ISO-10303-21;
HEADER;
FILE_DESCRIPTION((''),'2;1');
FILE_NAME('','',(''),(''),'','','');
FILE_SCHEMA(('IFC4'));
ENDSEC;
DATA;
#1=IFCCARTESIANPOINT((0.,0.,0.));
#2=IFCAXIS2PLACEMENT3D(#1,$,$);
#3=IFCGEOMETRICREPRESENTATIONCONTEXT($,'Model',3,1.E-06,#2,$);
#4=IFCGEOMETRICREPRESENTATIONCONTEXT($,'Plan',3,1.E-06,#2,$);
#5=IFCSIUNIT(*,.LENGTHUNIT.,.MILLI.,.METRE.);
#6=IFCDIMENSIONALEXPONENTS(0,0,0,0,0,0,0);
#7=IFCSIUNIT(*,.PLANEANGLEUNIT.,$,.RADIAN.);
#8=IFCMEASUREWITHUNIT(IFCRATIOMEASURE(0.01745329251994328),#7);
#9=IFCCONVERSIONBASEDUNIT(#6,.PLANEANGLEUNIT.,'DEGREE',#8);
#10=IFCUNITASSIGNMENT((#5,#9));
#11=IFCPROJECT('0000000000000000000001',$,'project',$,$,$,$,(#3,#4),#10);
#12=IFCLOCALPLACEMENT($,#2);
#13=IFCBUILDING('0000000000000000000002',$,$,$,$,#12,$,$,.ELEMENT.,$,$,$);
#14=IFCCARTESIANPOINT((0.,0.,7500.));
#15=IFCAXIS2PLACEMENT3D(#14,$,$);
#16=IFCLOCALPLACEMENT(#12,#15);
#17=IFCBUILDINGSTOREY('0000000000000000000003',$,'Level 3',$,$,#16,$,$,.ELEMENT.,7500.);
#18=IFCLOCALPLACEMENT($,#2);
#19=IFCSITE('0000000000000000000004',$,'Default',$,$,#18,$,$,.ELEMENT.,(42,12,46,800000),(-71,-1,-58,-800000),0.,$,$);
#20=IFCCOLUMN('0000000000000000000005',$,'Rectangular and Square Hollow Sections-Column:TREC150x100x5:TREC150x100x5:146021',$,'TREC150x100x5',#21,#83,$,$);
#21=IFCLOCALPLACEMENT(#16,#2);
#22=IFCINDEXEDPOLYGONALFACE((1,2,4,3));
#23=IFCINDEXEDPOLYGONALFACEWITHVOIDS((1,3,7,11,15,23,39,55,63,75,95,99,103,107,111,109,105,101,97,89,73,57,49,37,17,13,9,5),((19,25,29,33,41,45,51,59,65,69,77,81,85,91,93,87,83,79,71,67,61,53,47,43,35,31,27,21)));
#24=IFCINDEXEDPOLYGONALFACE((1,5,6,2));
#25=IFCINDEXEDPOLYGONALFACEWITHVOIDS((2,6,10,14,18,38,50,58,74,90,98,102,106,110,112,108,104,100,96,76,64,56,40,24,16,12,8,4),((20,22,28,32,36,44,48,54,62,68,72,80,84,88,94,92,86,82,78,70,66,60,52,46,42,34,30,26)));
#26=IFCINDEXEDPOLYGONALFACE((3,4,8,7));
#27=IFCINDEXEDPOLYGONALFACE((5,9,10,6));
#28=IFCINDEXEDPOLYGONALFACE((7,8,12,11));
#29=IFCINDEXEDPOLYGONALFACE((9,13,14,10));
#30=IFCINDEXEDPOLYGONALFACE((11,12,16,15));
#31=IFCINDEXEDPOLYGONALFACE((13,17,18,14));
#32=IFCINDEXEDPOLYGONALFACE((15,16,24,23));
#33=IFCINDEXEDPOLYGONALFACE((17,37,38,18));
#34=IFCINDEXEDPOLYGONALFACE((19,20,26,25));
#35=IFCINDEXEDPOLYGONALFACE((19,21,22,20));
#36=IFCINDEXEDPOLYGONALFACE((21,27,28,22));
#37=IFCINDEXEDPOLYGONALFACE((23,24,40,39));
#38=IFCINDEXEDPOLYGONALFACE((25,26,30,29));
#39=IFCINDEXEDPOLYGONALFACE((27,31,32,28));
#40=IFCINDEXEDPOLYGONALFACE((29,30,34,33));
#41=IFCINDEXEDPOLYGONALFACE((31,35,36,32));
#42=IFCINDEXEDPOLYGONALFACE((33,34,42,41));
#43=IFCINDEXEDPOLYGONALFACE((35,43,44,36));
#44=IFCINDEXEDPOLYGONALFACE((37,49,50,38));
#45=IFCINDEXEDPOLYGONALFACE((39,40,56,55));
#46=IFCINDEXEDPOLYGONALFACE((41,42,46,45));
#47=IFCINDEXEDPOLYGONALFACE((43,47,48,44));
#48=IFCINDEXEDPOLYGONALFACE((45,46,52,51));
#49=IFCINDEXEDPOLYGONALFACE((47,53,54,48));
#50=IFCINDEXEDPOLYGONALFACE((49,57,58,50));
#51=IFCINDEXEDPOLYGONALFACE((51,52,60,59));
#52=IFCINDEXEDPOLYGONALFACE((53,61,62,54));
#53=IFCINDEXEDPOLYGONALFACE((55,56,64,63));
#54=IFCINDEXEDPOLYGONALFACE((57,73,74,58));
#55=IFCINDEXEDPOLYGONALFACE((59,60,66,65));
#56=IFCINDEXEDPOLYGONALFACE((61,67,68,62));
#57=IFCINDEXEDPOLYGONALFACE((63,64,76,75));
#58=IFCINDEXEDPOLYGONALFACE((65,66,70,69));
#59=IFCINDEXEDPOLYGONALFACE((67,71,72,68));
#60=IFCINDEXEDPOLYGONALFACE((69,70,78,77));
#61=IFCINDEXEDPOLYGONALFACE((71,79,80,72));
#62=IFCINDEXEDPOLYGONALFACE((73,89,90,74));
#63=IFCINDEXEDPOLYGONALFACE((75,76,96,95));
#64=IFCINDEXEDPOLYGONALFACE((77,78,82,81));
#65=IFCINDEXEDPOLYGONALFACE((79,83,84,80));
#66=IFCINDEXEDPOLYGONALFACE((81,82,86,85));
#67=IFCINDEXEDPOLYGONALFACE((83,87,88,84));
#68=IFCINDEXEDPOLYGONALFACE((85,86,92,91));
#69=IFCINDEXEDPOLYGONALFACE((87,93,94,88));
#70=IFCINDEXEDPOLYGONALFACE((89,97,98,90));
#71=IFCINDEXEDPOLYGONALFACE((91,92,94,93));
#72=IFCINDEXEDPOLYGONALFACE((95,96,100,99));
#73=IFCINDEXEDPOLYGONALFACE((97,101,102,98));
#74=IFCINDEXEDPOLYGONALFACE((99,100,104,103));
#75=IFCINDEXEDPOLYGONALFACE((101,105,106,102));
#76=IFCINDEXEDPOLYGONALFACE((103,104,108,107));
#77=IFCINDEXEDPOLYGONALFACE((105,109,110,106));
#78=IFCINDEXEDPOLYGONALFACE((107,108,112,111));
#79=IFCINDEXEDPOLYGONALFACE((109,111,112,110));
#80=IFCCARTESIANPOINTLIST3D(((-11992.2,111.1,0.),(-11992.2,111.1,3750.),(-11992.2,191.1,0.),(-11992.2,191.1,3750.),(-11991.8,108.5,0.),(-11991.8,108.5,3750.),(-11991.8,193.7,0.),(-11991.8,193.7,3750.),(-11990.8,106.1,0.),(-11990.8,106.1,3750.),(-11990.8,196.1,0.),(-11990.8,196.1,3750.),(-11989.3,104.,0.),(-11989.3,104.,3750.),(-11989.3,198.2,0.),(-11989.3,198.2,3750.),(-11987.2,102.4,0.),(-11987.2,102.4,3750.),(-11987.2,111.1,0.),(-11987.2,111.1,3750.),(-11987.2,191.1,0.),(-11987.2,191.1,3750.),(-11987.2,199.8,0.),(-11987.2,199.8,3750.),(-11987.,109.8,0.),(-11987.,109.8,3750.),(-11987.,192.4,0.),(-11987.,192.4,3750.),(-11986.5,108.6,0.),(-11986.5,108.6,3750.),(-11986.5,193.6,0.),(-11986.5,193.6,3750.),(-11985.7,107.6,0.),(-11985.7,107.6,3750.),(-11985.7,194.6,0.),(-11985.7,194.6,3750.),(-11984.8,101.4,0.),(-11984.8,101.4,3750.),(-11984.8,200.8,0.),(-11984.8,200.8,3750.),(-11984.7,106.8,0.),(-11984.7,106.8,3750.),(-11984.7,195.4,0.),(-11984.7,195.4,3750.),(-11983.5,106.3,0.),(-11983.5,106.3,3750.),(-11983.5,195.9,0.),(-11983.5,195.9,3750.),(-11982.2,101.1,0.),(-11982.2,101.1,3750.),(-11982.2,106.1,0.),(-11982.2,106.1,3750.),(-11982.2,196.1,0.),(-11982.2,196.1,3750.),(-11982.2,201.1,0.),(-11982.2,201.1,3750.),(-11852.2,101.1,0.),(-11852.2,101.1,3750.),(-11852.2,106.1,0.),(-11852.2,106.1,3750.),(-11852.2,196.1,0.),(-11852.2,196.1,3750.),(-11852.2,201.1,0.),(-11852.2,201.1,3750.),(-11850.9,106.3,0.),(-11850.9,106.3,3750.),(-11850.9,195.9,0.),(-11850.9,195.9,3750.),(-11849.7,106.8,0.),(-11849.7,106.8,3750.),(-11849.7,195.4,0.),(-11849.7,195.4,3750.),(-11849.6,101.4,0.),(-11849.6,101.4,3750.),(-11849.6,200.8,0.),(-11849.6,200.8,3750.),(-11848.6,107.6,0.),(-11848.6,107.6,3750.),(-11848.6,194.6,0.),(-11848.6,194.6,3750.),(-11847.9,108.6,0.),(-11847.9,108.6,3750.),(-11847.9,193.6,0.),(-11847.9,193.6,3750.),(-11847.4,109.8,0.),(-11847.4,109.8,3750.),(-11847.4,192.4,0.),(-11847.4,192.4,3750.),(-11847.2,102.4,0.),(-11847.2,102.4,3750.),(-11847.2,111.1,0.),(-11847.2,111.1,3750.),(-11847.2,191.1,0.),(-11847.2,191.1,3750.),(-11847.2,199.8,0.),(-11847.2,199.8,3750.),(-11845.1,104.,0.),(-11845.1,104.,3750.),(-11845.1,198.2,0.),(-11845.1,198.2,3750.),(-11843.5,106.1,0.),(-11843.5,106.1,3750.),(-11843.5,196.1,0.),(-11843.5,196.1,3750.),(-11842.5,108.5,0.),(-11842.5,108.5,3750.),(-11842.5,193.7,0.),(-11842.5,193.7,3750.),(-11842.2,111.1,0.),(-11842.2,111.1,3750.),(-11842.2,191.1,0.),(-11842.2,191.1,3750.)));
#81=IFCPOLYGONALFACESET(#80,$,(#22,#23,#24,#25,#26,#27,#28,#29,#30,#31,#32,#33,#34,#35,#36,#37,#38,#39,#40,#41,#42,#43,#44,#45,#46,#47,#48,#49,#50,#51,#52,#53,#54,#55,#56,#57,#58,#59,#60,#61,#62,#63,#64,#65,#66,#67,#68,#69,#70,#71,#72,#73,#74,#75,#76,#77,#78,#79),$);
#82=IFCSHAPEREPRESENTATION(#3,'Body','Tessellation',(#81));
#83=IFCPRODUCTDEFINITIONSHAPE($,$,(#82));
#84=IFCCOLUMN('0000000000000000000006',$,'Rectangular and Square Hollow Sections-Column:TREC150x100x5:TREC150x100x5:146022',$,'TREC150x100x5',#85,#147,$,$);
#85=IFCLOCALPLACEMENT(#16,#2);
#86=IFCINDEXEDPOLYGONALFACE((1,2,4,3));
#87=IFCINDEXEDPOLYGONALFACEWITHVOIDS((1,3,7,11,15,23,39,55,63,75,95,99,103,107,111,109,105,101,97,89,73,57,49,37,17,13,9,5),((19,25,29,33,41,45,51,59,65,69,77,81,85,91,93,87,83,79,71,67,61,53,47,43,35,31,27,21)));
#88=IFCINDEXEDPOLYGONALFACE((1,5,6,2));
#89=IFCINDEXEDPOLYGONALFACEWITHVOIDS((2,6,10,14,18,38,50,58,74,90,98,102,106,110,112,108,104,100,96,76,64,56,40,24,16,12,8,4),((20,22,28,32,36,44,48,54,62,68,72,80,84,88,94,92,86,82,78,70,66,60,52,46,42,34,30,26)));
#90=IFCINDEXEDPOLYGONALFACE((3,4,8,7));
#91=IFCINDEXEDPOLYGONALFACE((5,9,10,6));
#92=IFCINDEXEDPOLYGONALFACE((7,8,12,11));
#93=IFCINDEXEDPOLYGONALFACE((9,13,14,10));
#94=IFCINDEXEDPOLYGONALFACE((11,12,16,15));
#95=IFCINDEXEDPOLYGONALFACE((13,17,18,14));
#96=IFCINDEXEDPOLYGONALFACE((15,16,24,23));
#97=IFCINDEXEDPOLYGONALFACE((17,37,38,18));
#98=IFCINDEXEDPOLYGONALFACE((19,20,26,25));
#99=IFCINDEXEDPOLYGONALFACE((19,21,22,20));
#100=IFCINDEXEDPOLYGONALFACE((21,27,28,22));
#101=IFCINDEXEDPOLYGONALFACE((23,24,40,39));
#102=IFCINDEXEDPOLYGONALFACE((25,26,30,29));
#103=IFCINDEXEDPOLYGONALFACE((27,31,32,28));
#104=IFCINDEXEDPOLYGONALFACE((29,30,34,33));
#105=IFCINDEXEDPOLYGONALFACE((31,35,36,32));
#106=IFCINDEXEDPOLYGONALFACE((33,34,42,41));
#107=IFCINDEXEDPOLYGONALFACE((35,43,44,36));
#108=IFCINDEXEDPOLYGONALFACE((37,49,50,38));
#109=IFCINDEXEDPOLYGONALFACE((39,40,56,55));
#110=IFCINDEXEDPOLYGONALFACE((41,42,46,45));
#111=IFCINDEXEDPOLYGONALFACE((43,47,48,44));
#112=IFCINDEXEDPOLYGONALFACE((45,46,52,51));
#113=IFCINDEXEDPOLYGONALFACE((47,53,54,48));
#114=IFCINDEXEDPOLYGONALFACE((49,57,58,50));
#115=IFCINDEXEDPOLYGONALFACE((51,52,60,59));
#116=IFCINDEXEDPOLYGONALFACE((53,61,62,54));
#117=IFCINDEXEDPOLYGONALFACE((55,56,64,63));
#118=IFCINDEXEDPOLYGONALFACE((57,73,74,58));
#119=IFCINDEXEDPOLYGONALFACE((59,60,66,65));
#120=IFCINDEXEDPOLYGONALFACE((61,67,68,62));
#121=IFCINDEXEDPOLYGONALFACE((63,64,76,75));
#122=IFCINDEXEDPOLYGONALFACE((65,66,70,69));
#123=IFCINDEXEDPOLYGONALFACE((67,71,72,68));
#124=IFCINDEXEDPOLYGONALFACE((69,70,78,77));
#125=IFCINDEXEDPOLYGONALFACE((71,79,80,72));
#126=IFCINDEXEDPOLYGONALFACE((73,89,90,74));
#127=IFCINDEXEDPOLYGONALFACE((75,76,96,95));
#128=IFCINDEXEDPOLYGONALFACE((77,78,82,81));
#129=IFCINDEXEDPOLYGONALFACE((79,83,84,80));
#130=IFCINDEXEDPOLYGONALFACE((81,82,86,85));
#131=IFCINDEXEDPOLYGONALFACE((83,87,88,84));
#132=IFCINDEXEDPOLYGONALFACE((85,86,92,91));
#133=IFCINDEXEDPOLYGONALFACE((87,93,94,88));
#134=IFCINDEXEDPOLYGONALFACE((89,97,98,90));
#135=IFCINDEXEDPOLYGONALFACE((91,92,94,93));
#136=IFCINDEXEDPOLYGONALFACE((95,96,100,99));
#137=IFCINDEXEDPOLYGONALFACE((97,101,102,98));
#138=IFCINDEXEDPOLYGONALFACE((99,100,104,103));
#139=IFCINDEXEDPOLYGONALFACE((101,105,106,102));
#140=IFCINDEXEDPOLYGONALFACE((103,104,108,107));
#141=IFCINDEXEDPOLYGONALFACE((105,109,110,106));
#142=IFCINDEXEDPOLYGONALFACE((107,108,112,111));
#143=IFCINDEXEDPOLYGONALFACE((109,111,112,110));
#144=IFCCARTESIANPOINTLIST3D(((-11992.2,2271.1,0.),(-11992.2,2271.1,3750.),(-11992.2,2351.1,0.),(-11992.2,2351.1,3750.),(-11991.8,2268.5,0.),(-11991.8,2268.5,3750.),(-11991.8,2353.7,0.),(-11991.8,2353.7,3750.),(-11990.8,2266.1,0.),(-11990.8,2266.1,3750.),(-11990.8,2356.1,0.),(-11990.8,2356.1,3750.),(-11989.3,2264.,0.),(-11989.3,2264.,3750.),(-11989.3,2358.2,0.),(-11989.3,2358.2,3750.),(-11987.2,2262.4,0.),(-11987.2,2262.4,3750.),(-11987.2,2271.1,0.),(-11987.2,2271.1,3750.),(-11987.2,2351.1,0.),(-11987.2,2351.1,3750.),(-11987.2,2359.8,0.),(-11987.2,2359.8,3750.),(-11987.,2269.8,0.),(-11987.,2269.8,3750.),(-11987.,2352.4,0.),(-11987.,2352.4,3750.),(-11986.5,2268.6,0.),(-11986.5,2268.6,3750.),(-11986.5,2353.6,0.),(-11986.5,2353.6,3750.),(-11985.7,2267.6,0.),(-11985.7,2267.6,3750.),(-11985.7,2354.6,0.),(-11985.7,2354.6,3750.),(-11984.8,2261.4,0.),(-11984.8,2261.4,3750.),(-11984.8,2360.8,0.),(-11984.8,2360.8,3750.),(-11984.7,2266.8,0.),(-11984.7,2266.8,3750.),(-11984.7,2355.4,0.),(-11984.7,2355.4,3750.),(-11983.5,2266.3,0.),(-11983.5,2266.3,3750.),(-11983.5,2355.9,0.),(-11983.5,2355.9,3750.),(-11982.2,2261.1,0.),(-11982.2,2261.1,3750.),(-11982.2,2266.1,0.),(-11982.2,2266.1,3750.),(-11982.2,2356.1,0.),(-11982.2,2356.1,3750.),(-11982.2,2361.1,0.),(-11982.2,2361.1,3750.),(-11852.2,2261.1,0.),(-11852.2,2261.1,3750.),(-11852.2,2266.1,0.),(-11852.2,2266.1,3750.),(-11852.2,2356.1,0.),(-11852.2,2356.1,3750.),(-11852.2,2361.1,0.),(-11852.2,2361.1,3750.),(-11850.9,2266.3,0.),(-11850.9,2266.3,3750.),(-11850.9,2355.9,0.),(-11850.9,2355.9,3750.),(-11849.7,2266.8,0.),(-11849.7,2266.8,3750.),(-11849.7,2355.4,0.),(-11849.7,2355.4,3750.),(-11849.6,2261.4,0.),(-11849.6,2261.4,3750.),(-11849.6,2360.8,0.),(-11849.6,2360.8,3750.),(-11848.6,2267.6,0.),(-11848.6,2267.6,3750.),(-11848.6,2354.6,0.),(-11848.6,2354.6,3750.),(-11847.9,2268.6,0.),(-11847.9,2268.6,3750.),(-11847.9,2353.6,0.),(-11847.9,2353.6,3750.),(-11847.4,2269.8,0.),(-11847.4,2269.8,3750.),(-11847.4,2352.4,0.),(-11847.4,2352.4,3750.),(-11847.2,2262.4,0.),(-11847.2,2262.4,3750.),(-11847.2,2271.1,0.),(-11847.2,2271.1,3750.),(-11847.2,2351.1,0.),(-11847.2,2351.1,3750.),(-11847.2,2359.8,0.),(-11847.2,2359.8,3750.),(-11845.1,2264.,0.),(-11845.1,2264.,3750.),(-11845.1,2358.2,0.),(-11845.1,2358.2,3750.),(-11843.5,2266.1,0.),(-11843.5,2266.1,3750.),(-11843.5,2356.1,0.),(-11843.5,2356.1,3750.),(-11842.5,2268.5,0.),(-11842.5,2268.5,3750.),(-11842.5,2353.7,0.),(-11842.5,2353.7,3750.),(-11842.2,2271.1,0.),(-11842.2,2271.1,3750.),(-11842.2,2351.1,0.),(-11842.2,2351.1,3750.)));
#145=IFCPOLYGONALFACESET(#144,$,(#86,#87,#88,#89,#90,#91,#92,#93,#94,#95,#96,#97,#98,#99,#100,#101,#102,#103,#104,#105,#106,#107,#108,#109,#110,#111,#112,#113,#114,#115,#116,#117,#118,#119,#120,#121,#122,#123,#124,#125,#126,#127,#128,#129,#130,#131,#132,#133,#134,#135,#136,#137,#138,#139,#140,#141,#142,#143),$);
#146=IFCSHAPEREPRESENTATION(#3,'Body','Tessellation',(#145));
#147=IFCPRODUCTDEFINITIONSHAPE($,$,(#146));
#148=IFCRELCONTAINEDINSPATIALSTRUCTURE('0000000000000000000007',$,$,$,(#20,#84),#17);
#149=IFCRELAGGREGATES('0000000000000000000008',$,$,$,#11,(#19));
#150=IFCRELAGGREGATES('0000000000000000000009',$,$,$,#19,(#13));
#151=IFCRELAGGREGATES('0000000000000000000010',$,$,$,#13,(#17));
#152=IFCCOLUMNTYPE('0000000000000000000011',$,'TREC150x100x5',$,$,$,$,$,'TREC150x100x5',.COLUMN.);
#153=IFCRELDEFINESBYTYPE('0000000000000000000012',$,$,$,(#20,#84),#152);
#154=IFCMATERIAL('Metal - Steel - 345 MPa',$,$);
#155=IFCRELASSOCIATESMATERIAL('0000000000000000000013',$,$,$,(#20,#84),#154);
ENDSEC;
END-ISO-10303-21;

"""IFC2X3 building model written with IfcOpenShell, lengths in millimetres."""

from ifc_helpers import new_model, entity, si_unit, converted_unit, frame, frame_2d, origin, place, context, project, spatial, polyline, circle_curve, parameter, trimmed, segment, composite_curve, outline, extrude, source, transform, mapped, material, type_object, type_shapes, element, save


model = new_model("IFC2X3")

# Units and contexts
model_context = context("Model", 3, precision=1e-06, world=origin())
plan_context = context("Plan", 3, precision=1e-06, world=origin())
ifc_project = project(units=[si_unit("LENGTHUNIT", "METRE", prefix="MILLI"), converted_unit("PLANEANGLEUNIT", "DEGREE", entity("IfcRatioMeasure", 0.01745329251994328), si_unit("PLANEANGLEUNIT", "RADIAN"), dimensions=[0, 0, 0, 0, 0, 0, 0])], contexts=[model_context, plan_context])

# Site, building, storey
site_placement = place(None, origin())
site = spatial("IfcSite", under=ifc_project, at=site_placement, Name="Default", CompositionType="ELEMENT", RefLatitude=(42, 12, 46, 800000), RefLongitude=(-71, -1, -58, -800000), RefElevation=0.0)
building_placement = place(None, origin())
building = spatial("IfcBuilding", under=site, at=building_placement, CompositionType="ELEMENT")
storey_placement = place(building_placement, frame((0.0, 0.0, 7500.0)))
storey = spatial("IfcBuildingStorey", under=building, at=storey_placement, Name="Level 3", CompositionType="ELEMENT", Elevation=7500.0)

# Columns
ifc_material_1 = material(Name="Metal - Steel - 345 MPa")
column_type = type_object("IfcColumnType", Name="TREC150x100x5", ElementType="TREC150x100x5", PredefinedType="COLUMN")
shared_shape = source(origin(), model_context, "Body", "SweptSolid", [
    extrude(outline(composite_curve([segment(polyline([(-40.0, -75.0), (40.0, -75.0)]), True, "CONTINUOUS"), segment(trimmed(circle_curve(frame_2d((40.0, -65.0), x_axis=(-1.0, 0.0)), 10.0), [parameter(90.0)], [parameter(180.0)], True, "PARAMETER"), True, "CONTINUOUS"), segment(polyline([(50.0, -65.0), (50.0, 65.0)]), True, "CONTINUOUS"), segment(trimmed(circle_curve(frame_2d((40.0, 65.0), x_axis=(-1.0, 0.0)), 10.0), [parameter(180.0)], [parameter(270.0)], True, "PARAMETER"), True, "CONTINUOUS"), segment(polyline([(40.0, 75.0), (-40.0, 75.0)]), True, "CONTINUOUS"), segment(trimmed(circle_curve(frame_2d((-40.0, 65.0), x_axis=(-1.0, 0.0)), 10.0), [parameter(270.0)], [parameter(360.0)], True, "PARAMETER"), True, "CONTINUOUS"), segment(polyline([(-50.0, 65.0), (-50.0, -65.0)]), True, "CONTINUOUS"), segment(trimmed(circle_curve(frame_2d((-40.0, -65.0), x_axis=(-1.0, 0.0)), 10.0), [parameter(360.0)], [parameter(90.0)], True, "PARAMETER"), True, "CONTINUOUS")], self_intersect=False), holes=[composite_curve([segment(trimmed(circle_curve(frame_2d((-40.0, -65.0), x_axis=(-1.0, 0.0)), 5.0), [parameter(0.0)], [parameter(90.0)], True, "PARAMETER"), False, "CONTINUOUS"), segment(polyline([(-45.0, -65.0), (-45.0, 65.0)]), True, "CONTINUOUS"), segment(trimmed(circle_curve(frame_2d((-40.0, 65.0), x_axis=(-1.0, 0.0)), 5.0), [parameter(270.0)], [parameter(360.0)], True, "PARAMETER"), False, "CONTINUOUS"), segment(polyline([(-40.0, 70.0), (40.0, 70.0)]), True, "CONTINUOUS"), segment(trimmed(circle_curve(frame_2d((40.0, 65.0), x_axis=(-1.0, 0.0)), 5.0), [parameter(180.0)], [parameter(270.0)], True, "PARAMETER"), False, "CONTINUOUS"), segment(polyline([(45.0, 65.0), (45.0, -65.0)]), True, "CONTINUOUS"), segment(trimmed(circle_curve(frame_2d((40.0, -65.0), x_axis=(-1.0, 0.0)), 5.0), [parameter(90.0)], [parameter(180.0)], True, "PARAMETER"), False, "CONTINUOUS"), segment(polyline([(40.0, -70.0), (-40.0, -70.0)]), True, "CONTINUOUS")], self_intersect=False)]), frame((0.0, 0.0, 7500.0), z_axis=(0.0, 0.0, 1.0), x_axis=(-1.0, 0.0, 0.0)), (0.0, 0.0, 1.0), 3750.0),
])
type_shapes(column_type, [shared_shape])
for number, where, z_axis, x_axis, name in (
    (1, (-11917.2, 151.1, -7500.0), (0.0, 0.0, 1.0), (0.0, 1.0, 0.0), "Rectangular and Square Hollow Sections-Column:TREC150x100x5:TREC150x100x5:146021"),
    (2, (-11917.2, 2311.1, -7500.0), (0.0, 0.0, 1.0), (0.0, 1.0, 0.0), "Rectangular and Square Hollow Sections-Column:TREC150x100x5:TREC150x100x5:146022"),
):
    element("IfcColumn", number, at=place(storey_placement, frame(where, z_axis=z_axis, x_axis=x_axis)), inside=storey, type_object=column_type, material=ifc_material_1, Name=name, ObjectType="TREC150x100x5", context=model_context, shape_type="MappedRepresentation", body=[
        mapped(shared_shape, transform((0.0, 0.0, 0.0), scale=1.0)),
    ])

save(model, "model.ifc")
